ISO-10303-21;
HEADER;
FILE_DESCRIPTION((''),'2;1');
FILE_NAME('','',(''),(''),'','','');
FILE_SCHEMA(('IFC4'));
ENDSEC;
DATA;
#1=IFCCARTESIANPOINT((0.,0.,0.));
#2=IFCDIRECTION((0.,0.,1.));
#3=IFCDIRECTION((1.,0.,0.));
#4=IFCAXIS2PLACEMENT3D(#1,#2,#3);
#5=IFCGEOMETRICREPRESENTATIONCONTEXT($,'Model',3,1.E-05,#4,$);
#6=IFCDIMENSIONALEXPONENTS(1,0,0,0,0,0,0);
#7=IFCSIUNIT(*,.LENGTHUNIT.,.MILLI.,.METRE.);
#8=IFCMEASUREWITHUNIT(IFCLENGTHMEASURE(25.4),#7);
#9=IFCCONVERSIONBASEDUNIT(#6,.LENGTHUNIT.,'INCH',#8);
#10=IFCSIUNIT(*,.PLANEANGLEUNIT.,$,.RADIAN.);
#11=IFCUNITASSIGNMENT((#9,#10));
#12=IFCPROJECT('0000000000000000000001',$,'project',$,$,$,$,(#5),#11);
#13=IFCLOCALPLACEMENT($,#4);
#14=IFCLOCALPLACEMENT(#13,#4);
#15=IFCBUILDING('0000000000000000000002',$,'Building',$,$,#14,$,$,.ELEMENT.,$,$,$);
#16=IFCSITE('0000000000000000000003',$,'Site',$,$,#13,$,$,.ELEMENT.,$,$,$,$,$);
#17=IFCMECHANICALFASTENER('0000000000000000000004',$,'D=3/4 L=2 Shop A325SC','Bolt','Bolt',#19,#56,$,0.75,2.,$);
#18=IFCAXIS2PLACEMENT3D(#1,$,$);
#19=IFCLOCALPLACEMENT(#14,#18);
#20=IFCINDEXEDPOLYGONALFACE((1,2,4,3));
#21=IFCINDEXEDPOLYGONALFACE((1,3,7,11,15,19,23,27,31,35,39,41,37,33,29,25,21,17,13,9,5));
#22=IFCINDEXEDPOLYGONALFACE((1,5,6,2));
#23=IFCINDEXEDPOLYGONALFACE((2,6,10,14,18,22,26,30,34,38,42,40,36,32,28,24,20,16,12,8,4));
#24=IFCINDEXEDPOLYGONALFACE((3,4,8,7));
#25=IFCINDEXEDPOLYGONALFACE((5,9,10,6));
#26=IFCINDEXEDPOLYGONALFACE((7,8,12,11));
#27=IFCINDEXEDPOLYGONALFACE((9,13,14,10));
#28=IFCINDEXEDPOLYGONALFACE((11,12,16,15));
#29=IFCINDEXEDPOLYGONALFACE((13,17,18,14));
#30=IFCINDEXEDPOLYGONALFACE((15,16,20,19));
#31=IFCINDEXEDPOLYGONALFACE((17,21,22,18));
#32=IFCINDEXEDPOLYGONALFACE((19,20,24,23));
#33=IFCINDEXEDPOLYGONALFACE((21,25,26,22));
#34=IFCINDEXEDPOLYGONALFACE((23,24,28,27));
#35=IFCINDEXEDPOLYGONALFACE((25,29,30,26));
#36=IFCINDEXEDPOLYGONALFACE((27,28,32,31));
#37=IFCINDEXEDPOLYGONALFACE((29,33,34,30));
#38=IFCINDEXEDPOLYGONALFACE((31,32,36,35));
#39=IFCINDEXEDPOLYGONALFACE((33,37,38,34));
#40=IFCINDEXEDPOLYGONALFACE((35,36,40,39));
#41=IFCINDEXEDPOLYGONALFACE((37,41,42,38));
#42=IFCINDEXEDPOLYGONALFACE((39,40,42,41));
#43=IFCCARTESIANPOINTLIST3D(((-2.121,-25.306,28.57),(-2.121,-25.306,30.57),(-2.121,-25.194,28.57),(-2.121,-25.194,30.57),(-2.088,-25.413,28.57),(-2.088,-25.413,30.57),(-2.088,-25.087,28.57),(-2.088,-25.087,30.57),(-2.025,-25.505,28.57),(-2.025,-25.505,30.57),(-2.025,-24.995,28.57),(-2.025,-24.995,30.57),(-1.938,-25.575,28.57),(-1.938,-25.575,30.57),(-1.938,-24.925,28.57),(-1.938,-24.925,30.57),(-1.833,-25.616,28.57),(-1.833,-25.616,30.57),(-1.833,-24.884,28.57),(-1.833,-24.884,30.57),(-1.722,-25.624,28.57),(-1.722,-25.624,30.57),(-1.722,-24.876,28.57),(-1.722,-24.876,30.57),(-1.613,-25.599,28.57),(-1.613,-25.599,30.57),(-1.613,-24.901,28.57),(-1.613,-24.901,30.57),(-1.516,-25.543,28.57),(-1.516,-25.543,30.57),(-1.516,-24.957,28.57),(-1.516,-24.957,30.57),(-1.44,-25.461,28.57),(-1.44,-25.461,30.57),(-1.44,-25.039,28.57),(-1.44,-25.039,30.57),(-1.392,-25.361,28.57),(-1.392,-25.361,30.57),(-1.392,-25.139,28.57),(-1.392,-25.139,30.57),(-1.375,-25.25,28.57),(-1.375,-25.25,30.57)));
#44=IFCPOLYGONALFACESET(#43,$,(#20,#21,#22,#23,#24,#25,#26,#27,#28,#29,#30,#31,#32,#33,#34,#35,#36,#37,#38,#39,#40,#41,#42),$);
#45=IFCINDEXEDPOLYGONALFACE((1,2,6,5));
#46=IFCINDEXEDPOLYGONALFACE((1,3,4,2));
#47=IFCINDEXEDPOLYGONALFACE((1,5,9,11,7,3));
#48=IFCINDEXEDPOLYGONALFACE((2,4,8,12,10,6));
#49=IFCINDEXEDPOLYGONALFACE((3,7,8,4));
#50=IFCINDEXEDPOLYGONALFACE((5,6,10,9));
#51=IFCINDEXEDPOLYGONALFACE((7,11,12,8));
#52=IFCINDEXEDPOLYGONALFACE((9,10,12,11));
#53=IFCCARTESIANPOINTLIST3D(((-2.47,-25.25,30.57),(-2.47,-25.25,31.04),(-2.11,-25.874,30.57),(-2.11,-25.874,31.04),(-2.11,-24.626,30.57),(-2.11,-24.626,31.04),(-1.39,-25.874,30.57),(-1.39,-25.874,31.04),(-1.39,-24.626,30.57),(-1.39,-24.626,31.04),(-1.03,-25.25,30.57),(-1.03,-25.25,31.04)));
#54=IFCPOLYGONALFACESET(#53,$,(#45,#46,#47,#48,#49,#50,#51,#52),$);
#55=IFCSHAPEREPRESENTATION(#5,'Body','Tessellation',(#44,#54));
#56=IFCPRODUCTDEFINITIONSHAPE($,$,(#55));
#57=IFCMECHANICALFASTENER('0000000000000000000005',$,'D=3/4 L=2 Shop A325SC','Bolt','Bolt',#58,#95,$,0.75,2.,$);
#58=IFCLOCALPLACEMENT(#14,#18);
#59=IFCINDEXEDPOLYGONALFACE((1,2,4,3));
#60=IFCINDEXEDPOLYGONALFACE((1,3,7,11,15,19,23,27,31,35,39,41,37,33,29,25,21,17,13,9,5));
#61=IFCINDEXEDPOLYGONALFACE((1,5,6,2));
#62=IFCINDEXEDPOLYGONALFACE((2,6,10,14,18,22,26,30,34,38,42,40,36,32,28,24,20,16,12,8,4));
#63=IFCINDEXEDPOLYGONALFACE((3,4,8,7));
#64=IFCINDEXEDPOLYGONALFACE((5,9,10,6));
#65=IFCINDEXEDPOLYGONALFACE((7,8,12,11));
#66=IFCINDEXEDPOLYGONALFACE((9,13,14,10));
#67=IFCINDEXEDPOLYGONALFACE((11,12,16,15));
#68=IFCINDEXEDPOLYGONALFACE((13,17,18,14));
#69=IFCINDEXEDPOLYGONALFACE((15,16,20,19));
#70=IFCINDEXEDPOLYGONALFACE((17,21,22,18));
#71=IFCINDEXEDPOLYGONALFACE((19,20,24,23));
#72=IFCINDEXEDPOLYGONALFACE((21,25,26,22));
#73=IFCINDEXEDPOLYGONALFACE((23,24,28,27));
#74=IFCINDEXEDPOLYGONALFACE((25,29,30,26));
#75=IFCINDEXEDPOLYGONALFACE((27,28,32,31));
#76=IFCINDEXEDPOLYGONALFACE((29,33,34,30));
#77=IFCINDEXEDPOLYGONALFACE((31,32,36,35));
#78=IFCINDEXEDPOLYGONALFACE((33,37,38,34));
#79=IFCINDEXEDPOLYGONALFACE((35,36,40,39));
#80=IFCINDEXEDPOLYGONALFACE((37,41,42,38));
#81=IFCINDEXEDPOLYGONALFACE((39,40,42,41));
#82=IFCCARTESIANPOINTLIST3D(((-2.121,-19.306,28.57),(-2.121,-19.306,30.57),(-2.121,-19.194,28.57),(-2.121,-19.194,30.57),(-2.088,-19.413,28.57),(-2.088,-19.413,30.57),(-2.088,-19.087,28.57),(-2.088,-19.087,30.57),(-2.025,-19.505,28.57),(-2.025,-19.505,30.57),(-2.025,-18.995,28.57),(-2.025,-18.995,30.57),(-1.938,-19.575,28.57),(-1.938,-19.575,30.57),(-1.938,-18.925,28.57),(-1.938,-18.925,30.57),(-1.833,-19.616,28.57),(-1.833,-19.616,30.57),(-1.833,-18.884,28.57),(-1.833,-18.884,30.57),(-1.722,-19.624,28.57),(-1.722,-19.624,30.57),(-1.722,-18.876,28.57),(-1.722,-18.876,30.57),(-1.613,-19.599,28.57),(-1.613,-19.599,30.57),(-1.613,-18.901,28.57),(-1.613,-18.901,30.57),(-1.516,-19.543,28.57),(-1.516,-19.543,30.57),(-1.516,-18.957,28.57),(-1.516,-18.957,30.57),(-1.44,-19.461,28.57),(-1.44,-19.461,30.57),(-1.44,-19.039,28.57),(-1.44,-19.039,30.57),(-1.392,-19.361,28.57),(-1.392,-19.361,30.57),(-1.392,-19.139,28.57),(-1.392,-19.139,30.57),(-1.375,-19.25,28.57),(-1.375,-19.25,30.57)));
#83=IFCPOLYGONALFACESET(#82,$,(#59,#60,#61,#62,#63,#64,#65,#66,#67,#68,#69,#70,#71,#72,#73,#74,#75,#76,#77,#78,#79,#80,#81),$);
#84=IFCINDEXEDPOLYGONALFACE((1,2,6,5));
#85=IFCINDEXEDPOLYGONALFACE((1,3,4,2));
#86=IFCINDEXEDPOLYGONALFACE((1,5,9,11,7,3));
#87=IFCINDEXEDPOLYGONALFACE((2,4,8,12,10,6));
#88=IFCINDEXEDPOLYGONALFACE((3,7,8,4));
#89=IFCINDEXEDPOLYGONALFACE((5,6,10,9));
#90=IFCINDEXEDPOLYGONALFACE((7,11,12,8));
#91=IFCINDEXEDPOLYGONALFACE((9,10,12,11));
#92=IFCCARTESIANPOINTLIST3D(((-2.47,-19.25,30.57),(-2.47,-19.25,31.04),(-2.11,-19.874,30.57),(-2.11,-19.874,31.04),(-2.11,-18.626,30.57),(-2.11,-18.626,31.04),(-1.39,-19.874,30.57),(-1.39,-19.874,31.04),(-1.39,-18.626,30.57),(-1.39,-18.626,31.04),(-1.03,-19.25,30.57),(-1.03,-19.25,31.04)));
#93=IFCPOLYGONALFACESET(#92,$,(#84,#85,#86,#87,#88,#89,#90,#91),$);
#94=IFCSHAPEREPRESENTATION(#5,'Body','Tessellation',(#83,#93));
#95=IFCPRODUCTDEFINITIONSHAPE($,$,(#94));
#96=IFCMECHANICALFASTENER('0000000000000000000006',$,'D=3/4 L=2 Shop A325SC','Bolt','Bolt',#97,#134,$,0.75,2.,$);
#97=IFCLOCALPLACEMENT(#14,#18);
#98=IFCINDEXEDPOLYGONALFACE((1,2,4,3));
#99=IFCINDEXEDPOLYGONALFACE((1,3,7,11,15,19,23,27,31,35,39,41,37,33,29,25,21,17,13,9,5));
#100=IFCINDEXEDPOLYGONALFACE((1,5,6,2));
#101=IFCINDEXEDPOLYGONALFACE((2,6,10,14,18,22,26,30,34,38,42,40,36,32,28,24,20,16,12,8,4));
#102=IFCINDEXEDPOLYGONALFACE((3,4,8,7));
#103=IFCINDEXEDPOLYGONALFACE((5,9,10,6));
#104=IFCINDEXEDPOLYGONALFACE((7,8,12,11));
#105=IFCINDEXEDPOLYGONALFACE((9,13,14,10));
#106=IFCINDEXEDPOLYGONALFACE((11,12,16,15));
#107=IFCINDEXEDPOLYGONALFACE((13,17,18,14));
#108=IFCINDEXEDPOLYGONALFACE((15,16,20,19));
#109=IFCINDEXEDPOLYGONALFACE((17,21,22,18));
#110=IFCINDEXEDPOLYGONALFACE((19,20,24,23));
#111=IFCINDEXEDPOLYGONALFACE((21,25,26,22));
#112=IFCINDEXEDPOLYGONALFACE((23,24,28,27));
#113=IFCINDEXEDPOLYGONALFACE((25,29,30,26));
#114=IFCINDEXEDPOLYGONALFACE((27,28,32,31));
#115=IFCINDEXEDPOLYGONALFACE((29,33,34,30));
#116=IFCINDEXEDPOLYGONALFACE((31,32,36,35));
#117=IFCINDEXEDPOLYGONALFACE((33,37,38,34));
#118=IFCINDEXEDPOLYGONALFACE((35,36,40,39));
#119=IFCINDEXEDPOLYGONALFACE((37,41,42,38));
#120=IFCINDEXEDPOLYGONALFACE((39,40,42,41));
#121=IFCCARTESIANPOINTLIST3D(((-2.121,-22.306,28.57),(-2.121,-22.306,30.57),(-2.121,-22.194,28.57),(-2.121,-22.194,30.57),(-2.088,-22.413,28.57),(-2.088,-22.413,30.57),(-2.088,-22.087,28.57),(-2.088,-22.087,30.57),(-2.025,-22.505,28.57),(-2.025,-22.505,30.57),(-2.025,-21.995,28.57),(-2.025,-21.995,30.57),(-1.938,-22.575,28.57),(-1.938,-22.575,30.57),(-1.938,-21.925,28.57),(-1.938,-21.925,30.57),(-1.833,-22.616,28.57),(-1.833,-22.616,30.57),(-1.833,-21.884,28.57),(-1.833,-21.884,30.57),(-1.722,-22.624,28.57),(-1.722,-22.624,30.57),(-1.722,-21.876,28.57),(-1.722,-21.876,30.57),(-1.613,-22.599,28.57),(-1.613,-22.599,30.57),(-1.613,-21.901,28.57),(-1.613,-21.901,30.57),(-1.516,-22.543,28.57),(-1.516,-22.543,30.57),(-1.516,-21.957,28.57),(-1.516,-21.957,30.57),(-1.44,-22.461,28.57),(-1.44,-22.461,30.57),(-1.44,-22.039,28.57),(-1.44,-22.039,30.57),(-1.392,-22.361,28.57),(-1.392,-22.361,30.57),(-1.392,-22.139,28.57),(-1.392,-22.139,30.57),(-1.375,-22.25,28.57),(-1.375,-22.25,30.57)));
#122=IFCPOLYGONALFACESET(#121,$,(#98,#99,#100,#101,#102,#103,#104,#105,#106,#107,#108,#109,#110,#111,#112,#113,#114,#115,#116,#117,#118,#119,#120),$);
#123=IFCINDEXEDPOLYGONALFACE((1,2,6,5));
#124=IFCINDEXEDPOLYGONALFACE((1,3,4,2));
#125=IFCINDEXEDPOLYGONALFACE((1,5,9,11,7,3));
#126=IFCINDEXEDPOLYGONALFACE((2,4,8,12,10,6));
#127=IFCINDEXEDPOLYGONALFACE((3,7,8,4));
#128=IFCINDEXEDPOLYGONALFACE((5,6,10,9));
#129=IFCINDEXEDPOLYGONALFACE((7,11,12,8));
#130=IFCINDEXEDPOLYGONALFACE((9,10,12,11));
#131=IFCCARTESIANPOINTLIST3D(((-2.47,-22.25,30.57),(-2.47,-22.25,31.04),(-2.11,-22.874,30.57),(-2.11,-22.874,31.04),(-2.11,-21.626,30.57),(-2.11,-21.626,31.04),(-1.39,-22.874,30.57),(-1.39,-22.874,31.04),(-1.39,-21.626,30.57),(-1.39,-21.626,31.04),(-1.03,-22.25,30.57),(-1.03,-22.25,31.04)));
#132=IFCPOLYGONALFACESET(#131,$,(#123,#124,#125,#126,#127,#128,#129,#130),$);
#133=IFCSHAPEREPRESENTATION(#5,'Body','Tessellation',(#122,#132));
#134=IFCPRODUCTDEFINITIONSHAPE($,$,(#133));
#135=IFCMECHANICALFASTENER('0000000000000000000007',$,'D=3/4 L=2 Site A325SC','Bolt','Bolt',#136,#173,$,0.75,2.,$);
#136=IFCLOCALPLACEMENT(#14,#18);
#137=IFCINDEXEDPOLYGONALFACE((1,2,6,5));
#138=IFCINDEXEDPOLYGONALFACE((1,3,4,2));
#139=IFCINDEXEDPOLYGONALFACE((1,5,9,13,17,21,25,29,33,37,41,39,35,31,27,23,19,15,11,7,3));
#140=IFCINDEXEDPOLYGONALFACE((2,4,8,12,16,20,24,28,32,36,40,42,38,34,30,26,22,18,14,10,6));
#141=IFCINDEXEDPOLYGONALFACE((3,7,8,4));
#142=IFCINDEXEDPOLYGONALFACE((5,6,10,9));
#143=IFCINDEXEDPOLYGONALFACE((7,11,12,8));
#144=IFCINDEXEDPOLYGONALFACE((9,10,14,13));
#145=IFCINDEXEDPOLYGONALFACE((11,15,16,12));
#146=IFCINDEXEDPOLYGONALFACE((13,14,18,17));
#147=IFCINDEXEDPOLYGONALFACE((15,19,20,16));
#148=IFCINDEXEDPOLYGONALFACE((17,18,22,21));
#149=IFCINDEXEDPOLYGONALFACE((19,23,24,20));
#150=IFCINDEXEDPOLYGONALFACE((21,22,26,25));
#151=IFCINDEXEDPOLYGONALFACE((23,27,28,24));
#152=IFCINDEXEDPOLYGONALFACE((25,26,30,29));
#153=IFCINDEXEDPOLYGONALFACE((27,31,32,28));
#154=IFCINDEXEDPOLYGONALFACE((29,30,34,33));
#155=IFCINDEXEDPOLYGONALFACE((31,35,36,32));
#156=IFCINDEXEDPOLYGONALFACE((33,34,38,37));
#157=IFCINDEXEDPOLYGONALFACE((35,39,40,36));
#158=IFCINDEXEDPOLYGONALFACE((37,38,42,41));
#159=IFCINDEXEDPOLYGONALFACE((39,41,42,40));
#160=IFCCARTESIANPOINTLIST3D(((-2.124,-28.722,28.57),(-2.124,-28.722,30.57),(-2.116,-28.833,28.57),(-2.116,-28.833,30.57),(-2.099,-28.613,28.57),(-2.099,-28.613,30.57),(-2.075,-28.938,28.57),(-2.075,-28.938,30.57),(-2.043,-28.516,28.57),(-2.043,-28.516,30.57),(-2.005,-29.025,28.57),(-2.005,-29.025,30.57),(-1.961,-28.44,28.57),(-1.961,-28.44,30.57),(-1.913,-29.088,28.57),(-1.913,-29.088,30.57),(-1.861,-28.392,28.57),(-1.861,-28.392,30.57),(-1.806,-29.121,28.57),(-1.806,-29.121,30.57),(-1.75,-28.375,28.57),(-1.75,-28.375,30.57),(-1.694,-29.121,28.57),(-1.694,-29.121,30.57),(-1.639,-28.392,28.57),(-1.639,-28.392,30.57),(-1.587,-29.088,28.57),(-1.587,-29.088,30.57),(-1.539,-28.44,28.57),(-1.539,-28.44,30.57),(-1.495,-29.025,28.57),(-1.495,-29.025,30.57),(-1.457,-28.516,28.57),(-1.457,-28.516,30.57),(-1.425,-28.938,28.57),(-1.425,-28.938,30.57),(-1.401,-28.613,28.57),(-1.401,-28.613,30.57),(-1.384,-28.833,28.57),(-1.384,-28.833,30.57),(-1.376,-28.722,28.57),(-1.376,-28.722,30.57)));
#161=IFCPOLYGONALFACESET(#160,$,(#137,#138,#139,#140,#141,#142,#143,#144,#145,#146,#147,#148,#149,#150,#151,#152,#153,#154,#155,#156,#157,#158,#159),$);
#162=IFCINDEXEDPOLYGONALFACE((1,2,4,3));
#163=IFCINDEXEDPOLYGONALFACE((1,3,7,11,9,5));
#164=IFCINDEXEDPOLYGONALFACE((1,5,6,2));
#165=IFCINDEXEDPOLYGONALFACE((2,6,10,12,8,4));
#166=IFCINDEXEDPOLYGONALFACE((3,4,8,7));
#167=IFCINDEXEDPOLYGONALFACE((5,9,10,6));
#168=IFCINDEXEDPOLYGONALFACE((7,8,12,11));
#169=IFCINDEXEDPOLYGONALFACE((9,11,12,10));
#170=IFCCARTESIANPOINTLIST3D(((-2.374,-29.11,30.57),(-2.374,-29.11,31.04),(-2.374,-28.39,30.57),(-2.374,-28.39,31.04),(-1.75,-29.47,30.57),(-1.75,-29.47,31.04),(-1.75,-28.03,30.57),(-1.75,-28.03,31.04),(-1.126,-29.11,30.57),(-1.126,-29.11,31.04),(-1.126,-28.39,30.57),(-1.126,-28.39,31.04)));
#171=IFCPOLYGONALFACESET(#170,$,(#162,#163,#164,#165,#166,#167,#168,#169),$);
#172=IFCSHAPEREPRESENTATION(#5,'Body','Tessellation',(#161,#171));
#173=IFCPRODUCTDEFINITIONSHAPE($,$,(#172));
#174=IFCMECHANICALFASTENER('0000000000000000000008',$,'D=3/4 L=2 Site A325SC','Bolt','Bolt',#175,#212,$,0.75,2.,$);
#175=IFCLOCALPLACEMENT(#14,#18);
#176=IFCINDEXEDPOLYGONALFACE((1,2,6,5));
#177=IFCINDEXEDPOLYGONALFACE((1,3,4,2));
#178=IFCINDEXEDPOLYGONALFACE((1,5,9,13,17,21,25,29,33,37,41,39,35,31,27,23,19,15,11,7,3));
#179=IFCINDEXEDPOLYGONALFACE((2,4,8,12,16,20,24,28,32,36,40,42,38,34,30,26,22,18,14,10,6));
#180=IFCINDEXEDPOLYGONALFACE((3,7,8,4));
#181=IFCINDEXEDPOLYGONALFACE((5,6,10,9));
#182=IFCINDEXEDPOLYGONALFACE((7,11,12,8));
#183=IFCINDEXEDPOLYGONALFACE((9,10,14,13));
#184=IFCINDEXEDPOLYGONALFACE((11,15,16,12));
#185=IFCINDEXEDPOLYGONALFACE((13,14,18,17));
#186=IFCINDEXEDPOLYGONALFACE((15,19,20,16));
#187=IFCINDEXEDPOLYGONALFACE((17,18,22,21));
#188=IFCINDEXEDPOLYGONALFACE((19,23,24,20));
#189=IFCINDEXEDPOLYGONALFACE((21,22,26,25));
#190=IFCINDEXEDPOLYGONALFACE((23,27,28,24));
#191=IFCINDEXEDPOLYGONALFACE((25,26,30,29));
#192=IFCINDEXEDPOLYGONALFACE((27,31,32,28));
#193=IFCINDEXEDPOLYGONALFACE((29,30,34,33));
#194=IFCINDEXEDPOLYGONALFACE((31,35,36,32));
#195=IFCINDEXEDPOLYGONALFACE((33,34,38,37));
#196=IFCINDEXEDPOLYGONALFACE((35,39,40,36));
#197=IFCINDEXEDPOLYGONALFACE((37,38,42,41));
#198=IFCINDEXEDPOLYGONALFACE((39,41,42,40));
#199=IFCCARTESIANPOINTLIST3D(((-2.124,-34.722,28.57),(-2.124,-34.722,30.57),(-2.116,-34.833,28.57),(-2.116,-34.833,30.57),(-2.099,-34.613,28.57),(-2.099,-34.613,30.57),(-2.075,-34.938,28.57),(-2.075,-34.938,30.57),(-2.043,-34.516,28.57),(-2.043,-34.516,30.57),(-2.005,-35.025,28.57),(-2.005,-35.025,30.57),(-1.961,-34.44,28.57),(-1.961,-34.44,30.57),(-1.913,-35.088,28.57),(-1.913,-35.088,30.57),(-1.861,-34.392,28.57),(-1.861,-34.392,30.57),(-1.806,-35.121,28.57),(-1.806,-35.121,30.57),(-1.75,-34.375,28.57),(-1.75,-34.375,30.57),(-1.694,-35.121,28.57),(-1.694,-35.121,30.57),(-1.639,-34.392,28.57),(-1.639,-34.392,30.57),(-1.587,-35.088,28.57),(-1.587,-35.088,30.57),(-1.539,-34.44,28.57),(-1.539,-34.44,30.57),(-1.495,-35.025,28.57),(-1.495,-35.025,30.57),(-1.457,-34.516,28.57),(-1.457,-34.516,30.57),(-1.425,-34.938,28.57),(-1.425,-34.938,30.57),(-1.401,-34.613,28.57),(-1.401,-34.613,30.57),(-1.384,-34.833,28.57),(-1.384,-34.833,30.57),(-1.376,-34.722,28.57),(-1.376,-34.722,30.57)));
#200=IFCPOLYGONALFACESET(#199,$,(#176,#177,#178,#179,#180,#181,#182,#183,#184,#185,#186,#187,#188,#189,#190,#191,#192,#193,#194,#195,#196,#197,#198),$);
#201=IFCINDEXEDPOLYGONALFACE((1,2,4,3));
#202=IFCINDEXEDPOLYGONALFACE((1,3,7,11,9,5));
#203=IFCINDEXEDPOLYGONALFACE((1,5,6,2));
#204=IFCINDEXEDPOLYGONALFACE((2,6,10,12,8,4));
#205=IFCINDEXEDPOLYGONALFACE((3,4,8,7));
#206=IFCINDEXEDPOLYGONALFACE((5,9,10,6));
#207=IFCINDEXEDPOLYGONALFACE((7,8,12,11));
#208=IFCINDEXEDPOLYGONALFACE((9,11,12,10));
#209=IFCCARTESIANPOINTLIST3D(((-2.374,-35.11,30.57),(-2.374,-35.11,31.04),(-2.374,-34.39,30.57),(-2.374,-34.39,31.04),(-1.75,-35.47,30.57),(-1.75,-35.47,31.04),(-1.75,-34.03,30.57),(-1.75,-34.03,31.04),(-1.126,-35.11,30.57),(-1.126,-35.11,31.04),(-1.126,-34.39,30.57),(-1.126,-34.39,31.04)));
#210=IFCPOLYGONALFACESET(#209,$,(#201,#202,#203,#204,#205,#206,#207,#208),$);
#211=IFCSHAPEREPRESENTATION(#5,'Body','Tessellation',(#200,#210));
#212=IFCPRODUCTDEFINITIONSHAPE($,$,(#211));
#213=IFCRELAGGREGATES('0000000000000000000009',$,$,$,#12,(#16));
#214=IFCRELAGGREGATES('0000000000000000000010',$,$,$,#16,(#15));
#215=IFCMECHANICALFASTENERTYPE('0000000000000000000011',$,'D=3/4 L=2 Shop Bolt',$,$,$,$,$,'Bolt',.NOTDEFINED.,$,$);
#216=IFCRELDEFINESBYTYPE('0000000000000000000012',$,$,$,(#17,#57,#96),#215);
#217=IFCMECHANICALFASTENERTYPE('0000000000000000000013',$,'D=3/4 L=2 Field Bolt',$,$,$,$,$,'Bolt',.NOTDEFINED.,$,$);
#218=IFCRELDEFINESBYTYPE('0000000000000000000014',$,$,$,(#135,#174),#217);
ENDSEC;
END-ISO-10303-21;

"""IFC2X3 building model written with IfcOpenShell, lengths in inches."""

from ifc_helpers import new_model, entity, si_unit, converted_unit, frame, origin_with_axes, origin_2d_with_axis, place, context, project, spatial, polyline, circle, outline, extrude, source, transform, mapped, type_object, type_shapes, element, save


model = new_model("IFC2X3")

# Units and contexts
model_context = context("Model", 3, precision=1e-05, world=origin_with_axes())
ifc_project = project(units=[converted_unit("LENGTHUNIT", "INCH", entity("IfcLengthMeasure", 25.4), si_unit("LENGTHUNIT", "METRE", prefix="MILLI"), dimensions=[1, 0, 0, 0, 0, 0, 0]), si_unit("PLANEANGLEUNIT", "RADIAN")], contexts=[model_context])

# Site, building
site_placement = place(None, origin_with_axes())
site = spatial("IfcSite", under=ifc_project, at=site_placement, Name="Site", CompositionType="ELEMENT")
building_placement = place(site_placement, origin_with_axes())
building = spatial("IfcBuilding", under=site, at=building_placement, Name="Building", CompositionType="ELEMENT")

# Mechanical fasteners
mechanical_fastener_type_1 = type_object("IfcMechanicalFastenerType", Name="D=3/4 L=2 Shop Bolt", ElementType="Bolt")
shared_shape_1 = source(origin_with_axes(), model_context, "Body", "SweptSolid", [
    extrude(circle(Radius=0.375, at=origin_2d_with_axis()), frame((0.0, 0.0, 0.0), z_axis=(1.0, 0.0, 0.0), x_axis=(0.0, 1.0, 0.0)), (0.0, 0.0, 1.0), 2.0),
    extrude(outline(polyline([(-0.72, 0.0), (-0.36, 0.624), (0.36, 0.624), (0.72, 0.0), (0.36, -0.624), (-0.36, -0.624), (-0.72, 0.0)])), frame((0.0, 0.0, 0.0), z_axis=(1.0, 0.0, 0.0), x_axis=(0.0, 1.0, 0.0)), (0.0, 0.0, -1.0), 0.47),
])
type_shapes(mechanical_fastener_type_1, [shared_shape_1])
placement_1 = place(building_placement, frame((0.0, 0.0, 46.0), z_axis=(0.0, 0.0, 1.0), x_axis=(0.0, -1.0, 0.0)))
placement_2 = place(placement_1, frame((25.25, -1.75, -15.43), z_axis=(1.0, 0.0, 0.0), x_axis=(0.0, 0.0, -1.0)))
for number, where, z_axis, x_axis, name in (
    (1, (0.0, 0.0, 0.0), (0.0, 0.0, 1.0), (1.0, 0.0, 0.0), "D=3/4 L=2 Shop A325SC"),
    (2, (0.0, 0.0, -6.0), (0.0, 0.0, 1.0), (1.0, 0.0, 0.0), "D=3/4 L=2 Shop A325SC"),
    (3, (0.0, 0.0, -3.0), (0.0, 0.0, 1.0), (1.0, 0.0, 0.0), "D=3/4 L=2 Shop A325SC"),
):
    element("IfcMechanicalFastener", number, at=place(placement_2, frame(where, z_axis=z_axis, x_axis=x_axis)), type_object=mechanical_fastener_type_1, Name=name, Description="Bolt", ObjectType="Bolt", NominalDiameter=0.75, NominalLength=2.0, context=model_context, shape_type="MappedRepresentation", body=[
        mapped(shared_shape_1, transform((0.0, 0.0, 0.0), scale=1.0)),
    ])
mechanical_fastener_type_2 = type_object("IfcMechanicalFastenerType", Name="D=3/4 L=2 Field Bolt", ElementType="Bolt")
shared_shape_2 = source(origin_with_axes(), model_context, "Body", "SweptSolid", [
    extrude(circle(Radius=0.375, at=origin_2d_with_axis()), frame((0.0, 0.0, 0.0), z_axis=(1.0, 0.0, 0.0), x_axis=(0.0, 1.0, 0.0)), (0.0, 0.0, 1.0), 2.0),
    extrude(outline(polyline([(-0.72, 0.0), (-0.36, 0.624), (0.36, 0.624), (0.72, 0.0), (0.36, -0.624), (-0.36, -0.624), (-0.72, 0.0)])), frame((0.0, 0.0, 0.0), z_axis=(1.0, 0.0, 0.0), x_axis=(0.0, 1.0, 0.0)), (0.0, 0.0, -1.0), 0.47),
])
type_shapes(mechanical_fastener_type_2, [shared_shape_2])
placement_3 = place(placement_1, frame((28.75, -1.75, -15.43), z_axis=(0.0, 1.0, 0.0), x_axis=(0.0, 0.0, -1.0)))
for number, where, z_axis, x_axis, name in (
    (4, (0.0, 0.0, 0.0), (0.0, 0.0, 1.0), (1.0, 0.0, 0.0), "D=3/4 L=2 Site A325SC"),
    (5, (0.0, -6.0, 0.0), (0.0, 0.0, 1.0), (1.0, 0.0, 0.0), "D=3/4 L=2 Site A325SC"),
):
    element("IfcMechanicalFastener", number, at=place(placement_3, frame(where, z_axis=z_axis, x_axis=x_axis)), type_object=mechanical_fastener_type_2, Name=name, Description="Bolt", ObjectType="Bolt", NominalDiameter=0.75, NominalLength=2.0, context=model_context, shape_type="MappedRepresentation", body=[
        mapped(shared_shape_2, transform((0.0, 0.0, 0.0), scale=1.0)),
    ])

save(model, "model.ifc")
